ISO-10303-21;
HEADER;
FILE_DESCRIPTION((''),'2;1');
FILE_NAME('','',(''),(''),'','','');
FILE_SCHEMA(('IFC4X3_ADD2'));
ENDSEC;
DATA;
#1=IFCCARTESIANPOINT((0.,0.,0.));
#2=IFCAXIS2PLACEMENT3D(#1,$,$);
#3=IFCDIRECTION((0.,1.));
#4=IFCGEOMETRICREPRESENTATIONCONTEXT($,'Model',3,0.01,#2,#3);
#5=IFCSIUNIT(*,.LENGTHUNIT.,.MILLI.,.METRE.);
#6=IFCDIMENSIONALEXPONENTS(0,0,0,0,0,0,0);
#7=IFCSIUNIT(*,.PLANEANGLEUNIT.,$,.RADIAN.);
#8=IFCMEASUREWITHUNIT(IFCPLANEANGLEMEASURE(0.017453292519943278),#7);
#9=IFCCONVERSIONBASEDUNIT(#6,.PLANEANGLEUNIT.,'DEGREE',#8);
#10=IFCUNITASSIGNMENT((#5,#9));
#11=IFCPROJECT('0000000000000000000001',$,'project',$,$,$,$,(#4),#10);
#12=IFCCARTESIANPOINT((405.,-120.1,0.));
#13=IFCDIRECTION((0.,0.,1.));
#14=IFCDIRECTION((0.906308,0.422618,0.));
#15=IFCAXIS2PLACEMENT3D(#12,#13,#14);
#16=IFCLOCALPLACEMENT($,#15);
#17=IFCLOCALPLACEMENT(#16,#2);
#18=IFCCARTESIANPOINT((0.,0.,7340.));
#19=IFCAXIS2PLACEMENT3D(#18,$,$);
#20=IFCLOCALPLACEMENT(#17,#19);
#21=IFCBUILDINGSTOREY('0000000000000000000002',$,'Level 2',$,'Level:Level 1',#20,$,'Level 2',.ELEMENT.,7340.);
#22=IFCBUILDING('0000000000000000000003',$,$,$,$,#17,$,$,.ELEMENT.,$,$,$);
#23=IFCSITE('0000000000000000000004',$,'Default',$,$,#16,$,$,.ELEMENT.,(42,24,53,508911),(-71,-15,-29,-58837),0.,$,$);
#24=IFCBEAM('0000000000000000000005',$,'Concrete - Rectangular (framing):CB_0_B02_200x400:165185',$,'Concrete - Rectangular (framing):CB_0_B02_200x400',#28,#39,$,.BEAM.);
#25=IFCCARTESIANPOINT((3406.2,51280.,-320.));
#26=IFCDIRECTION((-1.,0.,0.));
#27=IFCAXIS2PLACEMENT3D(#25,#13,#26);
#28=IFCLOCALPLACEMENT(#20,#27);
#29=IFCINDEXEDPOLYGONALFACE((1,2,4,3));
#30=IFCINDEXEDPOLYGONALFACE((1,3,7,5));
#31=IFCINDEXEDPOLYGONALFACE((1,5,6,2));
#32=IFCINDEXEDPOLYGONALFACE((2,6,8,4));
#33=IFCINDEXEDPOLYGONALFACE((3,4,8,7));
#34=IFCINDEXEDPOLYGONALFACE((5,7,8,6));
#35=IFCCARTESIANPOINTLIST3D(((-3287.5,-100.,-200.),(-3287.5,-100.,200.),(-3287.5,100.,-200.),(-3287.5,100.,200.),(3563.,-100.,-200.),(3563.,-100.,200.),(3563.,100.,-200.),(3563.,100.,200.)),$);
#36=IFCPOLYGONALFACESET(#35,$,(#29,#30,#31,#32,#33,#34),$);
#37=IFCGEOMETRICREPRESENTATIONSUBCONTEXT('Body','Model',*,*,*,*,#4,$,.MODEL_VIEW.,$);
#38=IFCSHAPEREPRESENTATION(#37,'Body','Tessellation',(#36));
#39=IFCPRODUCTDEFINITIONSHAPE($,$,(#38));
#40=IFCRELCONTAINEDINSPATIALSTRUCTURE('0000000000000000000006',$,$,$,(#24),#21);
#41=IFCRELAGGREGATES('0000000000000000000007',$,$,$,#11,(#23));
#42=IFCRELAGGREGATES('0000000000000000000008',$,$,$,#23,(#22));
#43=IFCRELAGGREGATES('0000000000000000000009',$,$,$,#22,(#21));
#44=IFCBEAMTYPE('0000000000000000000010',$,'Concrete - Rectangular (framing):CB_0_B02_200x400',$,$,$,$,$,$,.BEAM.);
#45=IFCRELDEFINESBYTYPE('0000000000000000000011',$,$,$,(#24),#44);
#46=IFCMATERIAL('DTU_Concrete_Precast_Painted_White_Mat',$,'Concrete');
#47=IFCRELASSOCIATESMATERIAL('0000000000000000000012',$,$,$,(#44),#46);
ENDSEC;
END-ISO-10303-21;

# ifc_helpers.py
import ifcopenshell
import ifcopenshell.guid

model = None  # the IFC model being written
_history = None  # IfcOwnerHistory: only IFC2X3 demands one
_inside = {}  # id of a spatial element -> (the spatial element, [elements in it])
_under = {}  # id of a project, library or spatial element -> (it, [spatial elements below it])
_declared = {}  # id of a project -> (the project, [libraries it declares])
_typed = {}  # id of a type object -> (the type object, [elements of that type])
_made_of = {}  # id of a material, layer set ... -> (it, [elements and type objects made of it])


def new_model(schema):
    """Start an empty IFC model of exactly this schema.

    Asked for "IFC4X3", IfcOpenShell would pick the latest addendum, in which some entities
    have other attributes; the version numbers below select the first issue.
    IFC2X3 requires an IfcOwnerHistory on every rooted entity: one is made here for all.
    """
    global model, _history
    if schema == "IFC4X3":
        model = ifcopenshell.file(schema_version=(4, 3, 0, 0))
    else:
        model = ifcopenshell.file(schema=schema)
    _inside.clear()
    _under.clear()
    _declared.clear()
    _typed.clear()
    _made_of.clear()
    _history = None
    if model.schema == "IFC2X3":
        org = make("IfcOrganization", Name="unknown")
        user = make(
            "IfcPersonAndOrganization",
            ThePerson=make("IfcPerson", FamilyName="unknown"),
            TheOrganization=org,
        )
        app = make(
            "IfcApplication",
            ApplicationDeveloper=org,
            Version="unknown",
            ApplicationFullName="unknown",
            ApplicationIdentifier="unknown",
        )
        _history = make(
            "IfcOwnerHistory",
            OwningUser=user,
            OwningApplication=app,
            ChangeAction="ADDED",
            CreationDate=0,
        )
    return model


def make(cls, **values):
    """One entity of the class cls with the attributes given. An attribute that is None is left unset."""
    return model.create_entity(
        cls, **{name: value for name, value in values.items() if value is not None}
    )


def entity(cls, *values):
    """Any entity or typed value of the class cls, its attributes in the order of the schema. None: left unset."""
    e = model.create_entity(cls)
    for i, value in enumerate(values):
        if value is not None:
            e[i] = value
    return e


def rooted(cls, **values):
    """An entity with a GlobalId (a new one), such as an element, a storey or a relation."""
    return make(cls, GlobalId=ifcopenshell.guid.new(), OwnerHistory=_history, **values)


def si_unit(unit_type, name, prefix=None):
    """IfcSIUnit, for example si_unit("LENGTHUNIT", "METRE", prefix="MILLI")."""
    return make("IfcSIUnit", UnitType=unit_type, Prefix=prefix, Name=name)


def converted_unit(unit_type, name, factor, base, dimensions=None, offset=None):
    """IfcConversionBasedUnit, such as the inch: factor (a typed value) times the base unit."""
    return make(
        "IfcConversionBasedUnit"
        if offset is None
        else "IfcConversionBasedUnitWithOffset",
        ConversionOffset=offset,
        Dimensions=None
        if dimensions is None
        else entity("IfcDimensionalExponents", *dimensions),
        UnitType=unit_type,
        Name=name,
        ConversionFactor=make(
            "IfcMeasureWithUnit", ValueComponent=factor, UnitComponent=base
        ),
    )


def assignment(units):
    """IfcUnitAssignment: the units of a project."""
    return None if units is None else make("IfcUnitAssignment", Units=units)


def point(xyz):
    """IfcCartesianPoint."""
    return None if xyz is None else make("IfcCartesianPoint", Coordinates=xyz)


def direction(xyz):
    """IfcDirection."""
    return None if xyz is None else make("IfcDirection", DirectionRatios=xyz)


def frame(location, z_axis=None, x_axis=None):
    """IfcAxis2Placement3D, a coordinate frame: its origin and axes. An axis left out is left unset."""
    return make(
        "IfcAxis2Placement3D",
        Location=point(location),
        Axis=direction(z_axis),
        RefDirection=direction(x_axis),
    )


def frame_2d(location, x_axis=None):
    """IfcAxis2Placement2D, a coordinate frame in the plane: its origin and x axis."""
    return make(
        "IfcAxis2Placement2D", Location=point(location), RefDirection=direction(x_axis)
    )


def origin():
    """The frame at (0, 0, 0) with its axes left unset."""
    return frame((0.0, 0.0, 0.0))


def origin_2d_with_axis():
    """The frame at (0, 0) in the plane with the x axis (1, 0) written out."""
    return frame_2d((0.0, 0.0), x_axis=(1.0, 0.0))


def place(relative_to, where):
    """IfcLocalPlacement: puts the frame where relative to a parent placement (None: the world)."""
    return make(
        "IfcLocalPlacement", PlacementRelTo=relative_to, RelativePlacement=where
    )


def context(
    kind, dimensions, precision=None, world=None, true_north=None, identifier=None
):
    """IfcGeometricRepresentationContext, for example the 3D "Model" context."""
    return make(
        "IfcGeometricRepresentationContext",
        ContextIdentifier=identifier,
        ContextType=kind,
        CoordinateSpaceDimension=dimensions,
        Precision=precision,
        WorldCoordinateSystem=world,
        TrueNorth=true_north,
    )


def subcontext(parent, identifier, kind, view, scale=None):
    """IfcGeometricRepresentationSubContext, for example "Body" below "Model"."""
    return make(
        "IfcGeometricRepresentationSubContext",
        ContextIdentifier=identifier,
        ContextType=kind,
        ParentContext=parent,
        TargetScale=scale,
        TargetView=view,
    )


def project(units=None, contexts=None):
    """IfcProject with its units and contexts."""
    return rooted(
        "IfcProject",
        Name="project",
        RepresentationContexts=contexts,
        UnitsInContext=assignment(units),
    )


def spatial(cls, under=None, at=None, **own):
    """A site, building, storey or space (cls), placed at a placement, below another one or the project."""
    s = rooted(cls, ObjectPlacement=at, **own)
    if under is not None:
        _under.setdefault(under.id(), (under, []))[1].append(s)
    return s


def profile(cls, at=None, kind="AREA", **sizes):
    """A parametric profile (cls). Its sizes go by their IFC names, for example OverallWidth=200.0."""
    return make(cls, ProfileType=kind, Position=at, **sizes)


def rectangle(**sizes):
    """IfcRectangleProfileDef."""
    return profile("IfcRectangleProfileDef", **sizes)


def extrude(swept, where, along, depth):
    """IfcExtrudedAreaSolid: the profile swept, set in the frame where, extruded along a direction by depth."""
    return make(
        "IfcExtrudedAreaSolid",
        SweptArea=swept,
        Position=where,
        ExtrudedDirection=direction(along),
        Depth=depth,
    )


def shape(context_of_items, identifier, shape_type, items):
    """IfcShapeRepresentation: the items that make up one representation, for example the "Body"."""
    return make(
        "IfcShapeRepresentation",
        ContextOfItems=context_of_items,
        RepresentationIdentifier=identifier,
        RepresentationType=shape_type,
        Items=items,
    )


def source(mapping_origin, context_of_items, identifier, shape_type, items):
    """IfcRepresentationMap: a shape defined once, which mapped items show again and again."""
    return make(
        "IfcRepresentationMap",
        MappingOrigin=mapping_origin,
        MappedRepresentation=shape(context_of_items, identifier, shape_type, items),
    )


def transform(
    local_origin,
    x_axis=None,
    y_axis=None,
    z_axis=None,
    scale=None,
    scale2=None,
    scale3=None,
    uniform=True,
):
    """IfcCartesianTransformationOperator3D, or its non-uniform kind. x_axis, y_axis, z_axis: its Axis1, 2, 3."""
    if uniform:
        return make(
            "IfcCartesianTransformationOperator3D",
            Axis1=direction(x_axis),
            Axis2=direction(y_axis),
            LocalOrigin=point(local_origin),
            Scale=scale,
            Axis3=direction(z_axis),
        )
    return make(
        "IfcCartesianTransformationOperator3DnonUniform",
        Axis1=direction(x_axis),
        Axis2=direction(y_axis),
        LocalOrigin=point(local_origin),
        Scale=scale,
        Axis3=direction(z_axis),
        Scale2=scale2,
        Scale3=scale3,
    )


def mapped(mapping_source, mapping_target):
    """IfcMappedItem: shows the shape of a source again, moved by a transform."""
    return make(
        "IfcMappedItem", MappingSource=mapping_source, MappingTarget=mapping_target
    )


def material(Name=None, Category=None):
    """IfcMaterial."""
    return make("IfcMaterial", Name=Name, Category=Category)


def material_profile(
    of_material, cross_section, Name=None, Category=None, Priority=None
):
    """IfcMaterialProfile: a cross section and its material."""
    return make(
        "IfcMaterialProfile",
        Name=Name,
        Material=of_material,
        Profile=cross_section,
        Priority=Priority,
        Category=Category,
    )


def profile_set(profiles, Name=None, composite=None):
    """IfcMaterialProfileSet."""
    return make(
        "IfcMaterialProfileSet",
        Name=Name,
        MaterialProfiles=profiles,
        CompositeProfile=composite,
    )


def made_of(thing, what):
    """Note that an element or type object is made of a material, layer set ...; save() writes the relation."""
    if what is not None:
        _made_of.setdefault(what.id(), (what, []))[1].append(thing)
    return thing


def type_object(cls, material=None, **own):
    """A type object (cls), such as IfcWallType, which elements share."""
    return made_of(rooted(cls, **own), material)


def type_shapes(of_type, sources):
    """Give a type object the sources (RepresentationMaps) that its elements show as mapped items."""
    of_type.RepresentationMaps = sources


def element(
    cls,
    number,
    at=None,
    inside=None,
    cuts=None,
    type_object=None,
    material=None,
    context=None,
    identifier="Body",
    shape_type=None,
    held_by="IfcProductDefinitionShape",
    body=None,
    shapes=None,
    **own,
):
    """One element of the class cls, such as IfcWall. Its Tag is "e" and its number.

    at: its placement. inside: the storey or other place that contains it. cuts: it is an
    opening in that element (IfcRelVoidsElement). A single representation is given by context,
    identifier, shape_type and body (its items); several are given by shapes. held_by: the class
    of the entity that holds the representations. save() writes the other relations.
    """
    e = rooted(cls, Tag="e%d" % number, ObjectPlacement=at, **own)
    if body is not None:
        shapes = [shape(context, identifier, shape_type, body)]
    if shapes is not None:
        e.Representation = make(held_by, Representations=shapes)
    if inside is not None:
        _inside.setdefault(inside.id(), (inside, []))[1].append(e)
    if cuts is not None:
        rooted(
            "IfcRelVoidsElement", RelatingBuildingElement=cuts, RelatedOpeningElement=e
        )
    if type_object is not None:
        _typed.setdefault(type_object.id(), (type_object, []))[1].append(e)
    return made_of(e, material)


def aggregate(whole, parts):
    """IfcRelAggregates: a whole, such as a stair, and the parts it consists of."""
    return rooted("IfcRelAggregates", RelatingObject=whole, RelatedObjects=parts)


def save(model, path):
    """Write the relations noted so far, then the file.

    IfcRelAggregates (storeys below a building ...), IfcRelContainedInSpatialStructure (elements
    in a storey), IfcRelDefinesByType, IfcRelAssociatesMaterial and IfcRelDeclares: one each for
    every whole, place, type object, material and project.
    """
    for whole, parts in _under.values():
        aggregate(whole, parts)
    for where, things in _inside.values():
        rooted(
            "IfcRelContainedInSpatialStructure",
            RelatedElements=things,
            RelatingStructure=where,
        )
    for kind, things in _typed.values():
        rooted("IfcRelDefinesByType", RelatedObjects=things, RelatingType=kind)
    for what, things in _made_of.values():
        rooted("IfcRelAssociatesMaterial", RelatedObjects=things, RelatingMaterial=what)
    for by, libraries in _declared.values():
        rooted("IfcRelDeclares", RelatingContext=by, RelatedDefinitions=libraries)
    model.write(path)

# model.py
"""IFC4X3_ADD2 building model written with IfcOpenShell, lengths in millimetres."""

from ifc_helpers import new_model, entity, si_unit, converted_unit, direction, frame, frame_2d, origin, origin_2d_with_axis, place, context, subcontext, project, spatial, rectangle, extrude, source, transform, mapped, material, material_profile, profile_set, type_object, type_shapes, element, save


model = new_model("IFC4X3_ADD2")

# Units and contexts
model_context = context("Model", 3, precision=0.01, world=origin(), true_north=direction((0.0, 1.0)))
body_context = subcontext(model_context, "Body", "Model", "MODEL_VIEW")
ifc_project = project(units=[si_unit("LENGTHUNIT", "METRE", prefix="MILLI"), converted_unit("PLANEANGLEUNIT", "DEGREE", entity("IfcPlaneAngleMeasure", 0.017453292519943278), si_unit("PLANEANGLEUNIT", "RADIAN"), dimensions=[0, 0, 0, 0, 0, 0, 0])], contexts=[model_context])

# Site, building, storey
site_placement = place(None, frame((405.0, -120.1, 0.0), z_axis=(0.0, 0.0, 1.0), x_axis=(0.906308, 0.422618, 0.0)))
site = spatial("IfcSite", under=ifc_project, at=site_placement, Name="Default", CompositionType="ELEMENT", RefLatitude=(42, 24, 53, 508911), RefLongitude=(-71, -15, -29, -58837), RefElevation=0.0)
building_placement = place(site_placement, origin())
building = spatial("IfcBuilding", under=site, at=building_placement, CompositionType="ELEMENT")
storey_placement = place(building_placement, frame((0.0, 0.0, 7340.0)))
storey = spatial("IfcBuildingStorey", under=building, at=storey_placement, Name="Level 2", ObjectType="Level:Level 1", LongName="Level 2", CompositionType="ELEMENT", Elevation=7340.0)

# Beam
ifc_material_1 = material(Name="DTU_Concrete_Precast_Painted_White_Mat", Category="Concrete")
ifc_material_profile_1 = material_profile(ifc_material_1, rectangle(XDim=7035.5, YDim=200.0, at=frame_2d((0.0, 0.0), x_axis=(1.0, 0.0))), Name="CB_0_B02_200x400")
ifc_profile_set_1 = profile_set([ifc_material_profile_1], Name="CB_0_B02_200x400")
beam_type_1 = type_object("IfcBeamType", Name="Concrete - Rectangular (framing):CB_0_B02_200x400", PredefinedType="BEAM", material=ifc_profile_set_1)
shared_shape_1 = source(origin(), body_context, "Body", "SweptSolid", [
    extrude(rectangle(XDim=6850.5, YDim=200.0, at=origin_2d_with_axis()), frame((137.7, 0.0, -200.0), z_axis=(0.0, 0.0, 1.0), x_axis=(-1.0, 0.0, 0.0)), (0.0, 0.0, 1.0), 400.0),
])
type_shapes(beam_type_1, [shared_shape_1])
beam_1_placement = place(storey_placement, frame((3406.2, 51280.0, -320.0), z_axis=(0.0, 0.0, 1.0), x_axis=(-1.0, 0.0, 0.0)))
element("IfcBeam", 1, at=beam_1_placement, inside=storey, type_object=beam_type_1, Name="Concrete - Rectangular (framing):CB_0_B02_200x400:165185", ObjectType="Concrete - Rectangular (framing):CB_0_B02_200x400", PredefinedType="BEAM", context=body_context, shape_type="MappedRepresentation", body=[
    mapped(shared_shape_1, transform((0.0, 0.0, 0.0), scale=1.0)),
])

save(model, "model.ifc")
